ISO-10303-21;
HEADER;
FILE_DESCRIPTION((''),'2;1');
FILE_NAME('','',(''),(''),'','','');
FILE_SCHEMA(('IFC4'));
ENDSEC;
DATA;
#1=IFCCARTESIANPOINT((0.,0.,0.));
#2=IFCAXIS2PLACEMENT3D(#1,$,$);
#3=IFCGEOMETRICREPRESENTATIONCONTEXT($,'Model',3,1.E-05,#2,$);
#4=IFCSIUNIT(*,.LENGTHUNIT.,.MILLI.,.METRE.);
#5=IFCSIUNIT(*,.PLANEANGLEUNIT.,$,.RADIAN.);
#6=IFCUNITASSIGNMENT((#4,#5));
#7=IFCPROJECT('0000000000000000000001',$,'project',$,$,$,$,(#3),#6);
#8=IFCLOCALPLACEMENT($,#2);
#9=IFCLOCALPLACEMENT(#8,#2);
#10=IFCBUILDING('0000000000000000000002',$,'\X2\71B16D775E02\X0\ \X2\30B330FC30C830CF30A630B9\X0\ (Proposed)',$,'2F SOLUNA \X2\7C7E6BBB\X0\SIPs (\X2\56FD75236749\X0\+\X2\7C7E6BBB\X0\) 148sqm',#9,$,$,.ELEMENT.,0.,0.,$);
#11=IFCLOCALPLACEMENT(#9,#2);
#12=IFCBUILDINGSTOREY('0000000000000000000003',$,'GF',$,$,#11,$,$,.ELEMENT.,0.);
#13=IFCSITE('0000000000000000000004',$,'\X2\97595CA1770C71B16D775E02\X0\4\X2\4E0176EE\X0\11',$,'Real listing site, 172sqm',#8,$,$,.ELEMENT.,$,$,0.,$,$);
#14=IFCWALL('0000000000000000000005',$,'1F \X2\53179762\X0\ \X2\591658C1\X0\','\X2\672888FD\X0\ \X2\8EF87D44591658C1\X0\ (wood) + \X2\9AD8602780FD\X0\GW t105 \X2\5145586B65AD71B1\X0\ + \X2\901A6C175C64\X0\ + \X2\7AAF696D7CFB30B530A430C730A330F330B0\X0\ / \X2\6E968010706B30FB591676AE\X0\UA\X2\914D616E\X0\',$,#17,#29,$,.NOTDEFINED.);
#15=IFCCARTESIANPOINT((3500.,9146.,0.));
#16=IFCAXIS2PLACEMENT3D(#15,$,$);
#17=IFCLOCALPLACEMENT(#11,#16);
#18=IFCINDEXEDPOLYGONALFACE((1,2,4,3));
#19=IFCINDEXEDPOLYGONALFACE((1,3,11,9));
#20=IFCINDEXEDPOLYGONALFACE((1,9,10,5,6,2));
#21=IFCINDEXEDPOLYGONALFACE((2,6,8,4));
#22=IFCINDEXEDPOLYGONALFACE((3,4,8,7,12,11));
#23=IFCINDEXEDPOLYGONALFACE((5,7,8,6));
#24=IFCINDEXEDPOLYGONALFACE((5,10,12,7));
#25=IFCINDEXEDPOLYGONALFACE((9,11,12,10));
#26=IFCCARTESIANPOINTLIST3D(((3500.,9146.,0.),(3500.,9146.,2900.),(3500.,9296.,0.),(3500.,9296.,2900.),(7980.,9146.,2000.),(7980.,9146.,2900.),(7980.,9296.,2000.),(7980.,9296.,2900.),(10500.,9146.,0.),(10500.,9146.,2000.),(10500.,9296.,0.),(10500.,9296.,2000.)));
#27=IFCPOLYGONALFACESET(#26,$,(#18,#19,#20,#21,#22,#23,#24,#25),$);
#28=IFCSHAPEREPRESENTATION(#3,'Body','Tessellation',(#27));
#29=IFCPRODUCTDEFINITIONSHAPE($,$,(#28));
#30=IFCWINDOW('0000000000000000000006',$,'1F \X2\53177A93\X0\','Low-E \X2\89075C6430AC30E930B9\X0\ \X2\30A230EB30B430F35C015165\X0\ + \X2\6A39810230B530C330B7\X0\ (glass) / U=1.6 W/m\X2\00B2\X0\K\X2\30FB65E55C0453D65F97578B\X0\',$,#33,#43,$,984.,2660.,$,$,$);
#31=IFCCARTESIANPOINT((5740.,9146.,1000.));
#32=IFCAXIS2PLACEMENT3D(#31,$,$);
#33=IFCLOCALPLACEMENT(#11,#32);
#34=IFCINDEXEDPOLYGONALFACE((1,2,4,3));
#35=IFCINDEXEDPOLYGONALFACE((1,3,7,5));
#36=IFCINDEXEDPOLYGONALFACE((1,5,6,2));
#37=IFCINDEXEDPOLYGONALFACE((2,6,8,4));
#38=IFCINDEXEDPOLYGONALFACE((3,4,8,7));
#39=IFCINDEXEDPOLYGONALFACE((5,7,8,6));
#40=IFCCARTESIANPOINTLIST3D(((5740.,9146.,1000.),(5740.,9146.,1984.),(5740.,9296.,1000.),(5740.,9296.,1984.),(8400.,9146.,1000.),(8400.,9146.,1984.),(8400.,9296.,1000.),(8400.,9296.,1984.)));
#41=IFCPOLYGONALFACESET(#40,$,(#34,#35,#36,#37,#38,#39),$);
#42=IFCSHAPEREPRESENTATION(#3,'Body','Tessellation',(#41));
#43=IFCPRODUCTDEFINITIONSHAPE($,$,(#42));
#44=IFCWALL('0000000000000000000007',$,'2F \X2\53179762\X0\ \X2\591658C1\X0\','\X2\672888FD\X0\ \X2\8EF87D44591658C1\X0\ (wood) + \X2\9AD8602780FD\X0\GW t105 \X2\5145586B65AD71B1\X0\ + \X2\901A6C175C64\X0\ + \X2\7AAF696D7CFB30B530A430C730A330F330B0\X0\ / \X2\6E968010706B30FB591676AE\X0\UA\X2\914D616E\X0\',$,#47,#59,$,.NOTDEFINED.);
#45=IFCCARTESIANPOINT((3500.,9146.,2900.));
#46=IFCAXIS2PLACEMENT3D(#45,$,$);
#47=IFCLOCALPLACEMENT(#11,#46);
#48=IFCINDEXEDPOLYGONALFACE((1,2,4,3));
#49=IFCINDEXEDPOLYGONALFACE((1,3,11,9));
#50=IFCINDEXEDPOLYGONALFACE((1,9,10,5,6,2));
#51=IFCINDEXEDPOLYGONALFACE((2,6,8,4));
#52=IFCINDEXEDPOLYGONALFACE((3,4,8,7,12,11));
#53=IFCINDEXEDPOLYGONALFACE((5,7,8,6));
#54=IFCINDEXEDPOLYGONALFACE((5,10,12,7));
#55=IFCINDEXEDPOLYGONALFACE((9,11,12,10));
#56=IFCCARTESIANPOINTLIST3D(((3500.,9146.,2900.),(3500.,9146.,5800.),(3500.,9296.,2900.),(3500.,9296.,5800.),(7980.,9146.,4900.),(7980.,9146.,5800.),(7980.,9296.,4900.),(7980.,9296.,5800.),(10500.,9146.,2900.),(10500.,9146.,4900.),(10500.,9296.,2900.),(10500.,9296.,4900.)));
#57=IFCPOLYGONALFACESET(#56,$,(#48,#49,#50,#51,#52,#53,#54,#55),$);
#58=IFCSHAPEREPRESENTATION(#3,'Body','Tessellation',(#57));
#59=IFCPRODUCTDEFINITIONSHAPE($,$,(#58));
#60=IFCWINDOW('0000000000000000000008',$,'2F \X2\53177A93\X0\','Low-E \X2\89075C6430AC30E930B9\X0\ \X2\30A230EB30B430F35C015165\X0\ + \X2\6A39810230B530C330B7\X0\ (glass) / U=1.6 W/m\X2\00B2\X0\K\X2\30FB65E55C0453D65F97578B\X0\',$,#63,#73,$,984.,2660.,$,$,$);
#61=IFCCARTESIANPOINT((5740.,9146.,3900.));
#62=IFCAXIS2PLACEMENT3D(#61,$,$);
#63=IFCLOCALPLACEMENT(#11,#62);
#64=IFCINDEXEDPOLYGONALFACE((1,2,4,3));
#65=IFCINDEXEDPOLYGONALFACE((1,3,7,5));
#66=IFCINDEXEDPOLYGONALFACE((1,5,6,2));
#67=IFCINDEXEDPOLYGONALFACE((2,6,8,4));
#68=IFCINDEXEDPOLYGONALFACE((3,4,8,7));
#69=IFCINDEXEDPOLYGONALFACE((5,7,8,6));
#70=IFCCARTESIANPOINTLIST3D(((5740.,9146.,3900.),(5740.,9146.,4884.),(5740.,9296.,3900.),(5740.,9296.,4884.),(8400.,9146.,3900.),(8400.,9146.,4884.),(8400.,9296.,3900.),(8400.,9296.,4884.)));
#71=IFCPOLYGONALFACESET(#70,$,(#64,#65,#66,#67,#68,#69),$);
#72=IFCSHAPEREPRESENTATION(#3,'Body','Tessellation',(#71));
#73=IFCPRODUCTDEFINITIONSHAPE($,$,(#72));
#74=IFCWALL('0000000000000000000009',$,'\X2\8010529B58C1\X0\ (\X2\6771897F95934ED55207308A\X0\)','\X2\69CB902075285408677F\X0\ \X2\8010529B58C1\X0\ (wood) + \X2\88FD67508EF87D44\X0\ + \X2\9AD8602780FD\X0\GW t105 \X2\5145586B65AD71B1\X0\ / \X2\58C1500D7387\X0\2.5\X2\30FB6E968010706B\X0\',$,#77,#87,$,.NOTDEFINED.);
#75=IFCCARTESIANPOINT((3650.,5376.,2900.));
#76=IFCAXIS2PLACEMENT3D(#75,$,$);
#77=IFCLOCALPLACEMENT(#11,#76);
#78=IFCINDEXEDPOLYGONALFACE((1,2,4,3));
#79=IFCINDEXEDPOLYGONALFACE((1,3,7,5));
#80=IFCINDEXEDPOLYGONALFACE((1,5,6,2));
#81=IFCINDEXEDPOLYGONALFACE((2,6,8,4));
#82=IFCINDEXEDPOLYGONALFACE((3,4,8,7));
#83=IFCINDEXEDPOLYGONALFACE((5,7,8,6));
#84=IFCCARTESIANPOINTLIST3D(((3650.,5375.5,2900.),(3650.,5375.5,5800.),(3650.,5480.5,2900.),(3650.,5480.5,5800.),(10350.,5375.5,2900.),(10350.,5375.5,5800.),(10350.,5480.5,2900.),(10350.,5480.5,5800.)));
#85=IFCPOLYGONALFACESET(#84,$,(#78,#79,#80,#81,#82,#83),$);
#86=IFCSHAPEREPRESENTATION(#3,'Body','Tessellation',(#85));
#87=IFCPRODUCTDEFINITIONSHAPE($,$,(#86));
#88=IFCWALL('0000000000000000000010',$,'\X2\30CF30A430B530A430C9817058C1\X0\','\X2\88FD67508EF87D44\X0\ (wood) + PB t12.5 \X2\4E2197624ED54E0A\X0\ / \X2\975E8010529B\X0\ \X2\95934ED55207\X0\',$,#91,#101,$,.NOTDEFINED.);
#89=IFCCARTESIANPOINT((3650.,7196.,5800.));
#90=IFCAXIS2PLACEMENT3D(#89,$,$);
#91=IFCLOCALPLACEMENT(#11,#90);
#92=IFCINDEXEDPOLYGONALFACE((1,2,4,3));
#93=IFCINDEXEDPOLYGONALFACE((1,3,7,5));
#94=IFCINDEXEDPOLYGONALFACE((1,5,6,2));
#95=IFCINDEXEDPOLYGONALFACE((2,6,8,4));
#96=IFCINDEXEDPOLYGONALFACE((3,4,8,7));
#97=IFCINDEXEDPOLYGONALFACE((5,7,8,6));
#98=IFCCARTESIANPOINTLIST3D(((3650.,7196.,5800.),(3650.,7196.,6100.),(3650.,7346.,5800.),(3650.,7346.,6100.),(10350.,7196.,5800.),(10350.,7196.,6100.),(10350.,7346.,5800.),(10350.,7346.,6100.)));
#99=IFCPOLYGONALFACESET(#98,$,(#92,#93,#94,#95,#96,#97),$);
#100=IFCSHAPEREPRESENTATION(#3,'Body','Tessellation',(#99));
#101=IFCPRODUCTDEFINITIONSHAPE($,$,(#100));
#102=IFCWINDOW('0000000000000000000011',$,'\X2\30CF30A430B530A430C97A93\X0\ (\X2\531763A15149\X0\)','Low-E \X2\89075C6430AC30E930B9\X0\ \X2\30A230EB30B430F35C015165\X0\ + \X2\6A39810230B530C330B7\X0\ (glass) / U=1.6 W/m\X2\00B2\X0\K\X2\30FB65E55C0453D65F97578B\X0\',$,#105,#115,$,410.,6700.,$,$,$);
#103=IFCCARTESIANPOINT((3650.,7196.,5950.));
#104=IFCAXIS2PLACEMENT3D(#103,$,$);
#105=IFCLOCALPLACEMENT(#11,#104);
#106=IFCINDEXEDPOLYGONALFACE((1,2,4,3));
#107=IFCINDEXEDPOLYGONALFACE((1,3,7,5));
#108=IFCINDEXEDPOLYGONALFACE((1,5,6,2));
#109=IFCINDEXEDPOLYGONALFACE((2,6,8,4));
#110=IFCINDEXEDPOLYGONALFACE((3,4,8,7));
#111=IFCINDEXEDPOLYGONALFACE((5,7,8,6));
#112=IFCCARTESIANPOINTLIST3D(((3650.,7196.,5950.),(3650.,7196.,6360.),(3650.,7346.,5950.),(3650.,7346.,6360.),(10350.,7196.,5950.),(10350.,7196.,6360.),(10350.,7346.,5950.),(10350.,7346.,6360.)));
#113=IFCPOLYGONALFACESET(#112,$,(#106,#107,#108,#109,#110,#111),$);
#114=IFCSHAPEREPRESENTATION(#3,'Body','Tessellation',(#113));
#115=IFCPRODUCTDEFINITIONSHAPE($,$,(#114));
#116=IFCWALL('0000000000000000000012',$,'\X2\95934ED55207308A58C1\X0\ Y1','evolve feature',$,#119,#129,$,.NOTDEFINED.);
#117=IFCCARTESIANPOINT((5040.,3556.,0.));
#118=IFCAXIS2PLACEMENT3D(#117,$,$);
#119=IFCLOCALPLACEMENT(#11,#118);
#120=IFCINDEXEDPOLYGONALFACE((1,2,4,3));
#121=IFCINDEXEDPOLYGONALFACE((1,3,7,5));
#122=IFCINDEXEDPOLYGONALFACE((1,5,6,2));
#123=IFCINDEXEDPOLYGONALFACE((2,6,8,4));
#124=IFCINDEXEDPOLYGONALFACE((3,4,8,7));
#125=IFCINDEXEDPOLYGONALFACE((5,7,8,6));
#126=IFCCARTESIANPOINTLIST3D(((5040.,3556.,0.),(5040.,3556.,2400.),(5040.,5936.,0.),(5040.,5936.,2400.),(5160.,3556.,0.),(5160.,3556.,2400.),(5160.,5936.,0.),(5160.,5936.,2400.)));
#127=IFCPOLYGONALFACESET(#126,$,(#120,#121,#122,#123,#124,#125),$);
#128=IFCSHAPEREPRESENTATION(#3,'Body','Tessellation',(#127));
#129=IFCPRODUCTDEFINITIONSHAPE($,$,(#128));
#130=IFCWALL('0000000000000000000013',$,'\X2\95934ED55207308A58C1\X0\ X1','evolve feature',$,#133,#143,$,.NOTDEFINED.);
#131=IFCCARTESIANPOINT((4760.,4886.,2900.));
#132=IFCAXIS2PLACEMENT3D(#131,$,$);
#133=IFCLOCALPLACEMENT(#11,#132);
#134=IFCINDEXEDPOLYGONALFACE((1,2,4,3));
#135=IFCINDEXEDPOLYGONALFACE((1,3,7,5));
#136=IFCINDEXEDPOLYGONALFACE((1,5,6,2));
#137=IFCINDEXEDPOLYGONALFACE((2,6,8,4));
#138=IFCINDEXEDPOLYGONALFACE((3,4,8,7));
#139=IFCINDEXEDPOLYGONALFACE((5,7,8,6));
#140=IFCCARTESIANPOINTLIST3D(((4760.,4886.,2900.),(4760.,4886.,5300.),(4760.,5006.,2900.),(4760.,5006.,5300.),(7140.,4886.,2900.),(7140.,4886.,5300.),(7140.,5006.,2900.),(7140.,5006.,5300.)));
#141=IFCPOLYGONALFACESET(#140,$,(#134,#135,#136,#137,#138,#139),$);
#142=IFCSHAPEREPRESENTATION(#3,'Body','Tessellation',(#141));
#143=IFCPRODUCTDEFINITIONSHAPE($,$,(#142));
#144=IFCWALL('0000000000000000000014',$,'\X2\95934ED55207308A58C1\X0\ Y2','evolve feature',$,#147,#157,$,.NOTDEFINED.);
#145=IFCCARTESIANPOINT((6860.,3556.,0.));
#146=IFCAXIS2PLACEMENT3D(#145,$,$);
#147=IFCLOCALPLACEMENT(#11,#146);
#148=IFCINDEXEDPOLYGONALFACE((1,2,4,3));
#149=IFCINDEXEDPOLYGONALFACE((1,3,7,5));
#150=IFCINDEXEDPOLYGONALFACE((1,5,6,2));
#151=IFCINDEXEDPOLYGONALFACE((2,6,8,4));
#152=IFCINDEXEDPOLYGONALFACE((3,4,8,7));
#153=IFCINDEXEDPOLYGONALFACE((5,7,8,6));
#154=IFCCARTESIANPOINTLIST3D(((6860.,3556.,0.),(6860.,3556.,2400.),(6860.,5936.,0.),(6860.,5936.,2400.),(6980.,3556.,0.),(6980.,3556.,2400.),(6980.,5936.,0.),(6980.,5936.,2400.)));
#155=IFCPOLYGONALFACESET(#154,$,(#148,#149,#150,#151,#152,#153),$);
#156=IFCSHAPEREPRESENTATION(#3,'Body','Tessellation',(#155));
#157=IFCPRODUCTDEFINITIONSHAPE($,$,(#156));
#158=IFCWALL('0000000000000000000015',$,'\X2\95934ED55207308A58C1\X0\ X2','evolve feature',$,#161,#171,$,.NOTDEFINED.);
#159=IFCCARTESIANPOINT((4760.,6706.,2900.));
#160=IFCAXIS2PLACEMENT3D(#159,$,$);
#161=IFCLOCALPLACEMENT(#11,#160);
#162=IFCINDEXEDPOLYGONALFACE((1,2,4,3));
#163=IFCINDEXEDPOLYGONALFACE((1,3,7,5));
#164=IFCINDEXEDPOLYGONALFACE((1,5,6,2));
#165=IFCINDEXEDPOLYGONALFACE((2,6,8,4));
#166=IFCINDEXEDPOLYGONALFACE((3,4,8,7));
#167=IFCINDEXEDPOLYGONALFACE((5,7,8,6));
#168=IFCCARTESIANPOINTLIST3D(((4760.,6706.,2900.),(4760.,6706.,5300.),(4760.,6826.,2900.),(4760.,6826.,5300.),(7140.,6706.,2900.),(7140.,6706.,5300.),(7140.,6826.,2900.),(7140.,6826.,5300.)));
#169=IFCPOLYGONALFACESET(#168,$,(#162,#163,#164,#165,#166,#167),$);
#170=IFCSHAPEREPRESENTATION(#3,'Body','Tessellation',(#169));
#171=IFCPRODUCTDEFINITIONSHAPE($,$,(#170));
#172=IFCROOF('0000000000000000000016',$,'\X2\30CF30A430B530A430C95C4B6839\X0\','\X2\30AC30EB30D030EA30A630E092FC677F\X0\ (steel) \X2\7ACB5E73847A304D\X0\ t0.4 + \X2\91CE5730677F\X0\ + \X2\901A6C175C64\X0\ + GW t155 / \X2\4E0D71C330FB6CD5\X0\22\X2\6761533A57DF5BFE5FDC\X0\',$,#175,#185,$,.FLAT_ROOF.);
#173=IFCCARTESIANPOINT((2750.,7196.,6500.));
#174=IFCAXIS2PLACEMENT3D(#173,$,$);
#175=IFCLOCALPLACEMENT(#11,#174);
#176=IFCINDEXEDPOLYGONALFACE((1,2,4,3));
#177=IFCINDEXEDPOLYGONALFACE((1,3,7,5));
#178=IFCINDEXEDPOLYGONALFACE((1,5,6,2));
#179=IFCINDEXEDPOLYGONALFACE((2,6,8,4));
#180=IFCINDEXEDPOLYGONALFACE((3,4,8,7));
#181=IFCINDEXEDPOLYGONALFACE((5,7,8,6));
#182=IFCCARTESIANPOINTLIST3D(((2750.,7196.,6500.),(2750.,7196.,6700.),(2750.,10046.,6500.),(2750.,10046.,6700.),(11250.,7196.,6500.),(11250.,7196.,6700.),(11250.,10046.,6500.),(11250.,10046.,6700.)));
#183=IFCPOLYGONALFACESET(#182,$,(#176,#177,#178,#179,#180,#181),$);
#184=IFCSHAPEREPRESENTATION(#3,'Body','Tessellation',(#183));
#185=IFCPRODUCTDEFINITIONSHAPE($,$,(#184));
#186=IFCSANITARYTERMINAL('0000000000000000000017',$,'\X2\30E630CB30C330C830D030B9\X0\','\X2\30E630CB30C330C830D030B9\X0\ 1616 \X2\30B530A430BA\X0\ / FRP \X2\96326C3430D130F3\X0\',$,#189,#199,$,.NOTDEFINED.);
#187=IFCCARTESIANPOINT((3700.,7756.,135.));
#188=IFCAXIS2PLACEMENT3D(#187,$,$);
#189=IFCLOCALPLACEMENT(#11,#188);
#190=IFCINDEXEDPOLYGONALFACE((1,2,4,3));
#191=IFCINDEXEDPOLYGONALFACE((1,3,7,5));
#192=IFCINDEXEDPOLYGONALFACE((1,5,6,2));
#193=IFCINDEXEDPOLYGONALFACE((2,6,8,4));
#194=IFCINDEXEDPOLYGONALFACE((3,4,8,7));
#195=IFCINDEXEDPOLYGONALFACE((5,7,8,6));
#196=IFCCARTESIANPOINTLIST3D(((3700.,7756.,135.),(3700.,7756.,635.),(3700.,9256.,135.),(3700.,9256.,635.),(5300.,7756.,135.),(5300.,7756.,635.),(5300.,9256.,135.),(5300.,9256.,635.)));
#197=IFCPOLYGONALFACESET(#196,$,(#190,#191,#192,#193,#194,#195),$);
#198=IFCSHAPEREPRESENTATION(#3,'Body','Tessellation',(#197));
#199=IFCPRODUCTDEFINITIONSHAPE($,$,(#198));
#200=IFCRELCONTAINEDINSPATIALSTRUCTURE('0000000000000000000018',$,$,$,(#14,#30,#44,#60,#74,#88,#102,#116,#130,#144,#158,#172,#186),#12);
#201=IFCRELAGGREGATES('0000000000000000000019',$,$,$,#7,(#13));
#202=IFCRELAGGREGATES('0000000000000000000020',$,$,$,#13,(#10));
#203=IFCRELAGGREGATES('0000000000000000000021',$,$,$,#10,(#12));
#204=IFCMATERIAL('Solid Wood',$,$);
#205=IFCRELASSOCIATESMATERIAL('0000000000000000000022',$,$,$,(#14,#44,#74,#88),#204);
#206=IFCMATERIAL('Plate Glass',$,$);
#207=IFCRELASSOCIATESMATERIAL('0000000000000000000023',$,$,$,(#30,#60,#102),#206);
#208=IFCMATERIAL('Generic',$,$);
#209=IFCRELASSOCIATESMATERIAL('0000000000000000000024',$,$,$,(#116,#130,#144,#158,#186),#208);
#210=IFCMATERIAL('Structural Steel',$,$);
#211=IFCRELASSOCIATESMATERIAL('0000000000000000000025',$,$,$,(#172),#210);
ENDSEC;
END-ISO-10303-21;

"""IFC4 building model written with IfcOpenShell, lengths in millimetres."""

from ifc_helpers import new_model, si_unit, frame, frame_2d, origin, place, context, project, spatial, rectangle, extrude, material, element, fill, save


model = new_model("IFC4")

# Units and contexts
model_context = context("Model", 3, precision=1e-05, world=origin())
ifc_project = project(units=[si_unit("LENGTHUNIT", "METRE", prefix="MILLI"), si_unit("PLANEANGLEUNIT", "RADIAN")], contexts=[model_context])

# Site, building, storey
site_placement = place(None, origin())
site = spatial("IfcSite", under=ifc_project, at=site_placement, Name="静岡県熱海市4丁目11", ObjectType="Real listing site, 172sqm", CompositionType="ELEMENT", RefElevation=0.0)
building_placement = place(site_placement, origin())
building = spatial("IfcBuilding", under=site, at=building_placement, Name="熱海市 コートハウス (Proposed)", ObjectType="2F SOLUNA 籾殻SIPs (国産杉+籾殻) 148sqm", CompositionType="ELEMENT", ElevationOfRefHeight=0.0, ElevationOfTerrain=0.0)
storey_placement = place(building_placement, origin())
storey = spatial("IfcBuildingStorey", under=building, at=storey_placement, Name="GF", CompositionType="ELEMENT", Elevation=0.0)

# Wall, opening, window
ifc_material_1 = material(Name="Solid Wood")
wall_1_placement = place(storey_placement, frame((3500.0, 9146.0, 0.0)))
wall_1 = element("IfcWall", 1, at=wall_1_placement, inside=storey, material=ifc_material_1, Name="1F 北面 外壁", Description="木製 軸組外壁 (wood) + 高性能GW t105 充填断熱 + 通気層 + 窯業系サイディング / 準耐火・外皮UA配慮", PredefinedType="NOTDEFINED", context=model_context, shape_type="SweptSolid", body=[
    extrude(rectangle(XDim=7000.0, YDim=150.0, at=frame_2d((3500.0, 75.0))), frame((3500.0, 9146.0, 0.0)), (0.0, 0.0, 1.0), 2900.0),
])
opening_1_placement = place(storey_placement, frame((5740.0, 9146.0, 1000.0)))
opening_1 = element("IfcOpeningElement", 2, at=opening_1_placement, cuts=wall_1, PredefinedType="NOTDEFINED", context=model_context, shape_type="SweptSolid", body=[
    extrude(rectangle(XDim=2660.0, YDim=150.0, at=frame_2d((1330.0, 75.0))), frame((5740.0, 9146.0, 1000.0)), (0.0, 0.0, 1.0), 984.0),
])
ifc_material_2 = material(Name="Plate Glass")
window_1_placement = place(storey_placement, frame((5740.0, 9146.0, 1000.0)))
window_1 = element("IfcWindow", 3, at=window_1_placement, inside=storey, material=ifc_material_2, Name="1F 北窓", Description="Low-E 複層ガラス アルゴン封入 + 樹脂サッシ (glass) / U=1.6 W/m²K・日射取得型", OverallHeight=984.0, OverallWidth=2660.0, context=model_context, shape_type="SweptSolid", body=[
    extrude(rectangle(XDim=2660.0, YDim=150.0, at=frame_2d((1330.0, 75.0))), frame((5740.0, 9146.0, 1000.0)), (0.0, 0.0, 1.0), 984.0),
])
fill(opening_1, window_1)

# Wall, opening, window
wall_2_placement = place(storey_placement, frame((3500.0, 9146.0, 2900.0)))
wall_2 = element("IfcWall", 4, at=wall_2_placement, inside=storey, material=ifc_material_1, Name="2F 北面 外壁", Description="木製 軸組外壁 (wood) + 高性能GW t105 充填断熱 + 通気層 + 窯業系サイディング / 準耐火・外皮UA配慮", PredefinedType="NOTDEFINED", context=model_context, shape_type="SweptSolid", body=[
    extrude(rectangle(XDim=7000.0, YDim=150.0, at=frame_2d((3500.0, 75.0))), frame((3500.0, 9146.0, 2900.0)), (0.0, 0.0, 1.0), 2900.0),
])
opening_2_placement = place(storey_placement, frame((5740.0, 9146.0, 3900.0)))
opening_2 = element("IfcOpeningElement", 5, at=opening_2_placement, cuts=wall_2, PredefinedType="NOTDEFINED", context=model_context, shape_type="SweptSolid", body=[
    extrude(rectangle(XDim=2660.0, YDim=150.0, at=frame_2d((1330.0, 75.0))), frame((5740.0, 9146.0, 3900.0)), (0.0, 0.0, 1.0), 984.0),
])
window_2_placement = place(storey_placement, frame((5740.0, 9146.0, 3900.0)))
window_2 = element("IfcWindow", 6, at=window_2_placement, inside=storey, material=ifc_material_2, Name="2F 北窓", Description="Low-E 複層ガラス アルゴン封入 + 樹脂サッシ (glass) / U=1.6 W/m²K・日射取得型", OverallHeight=984.0, OverallWidth=2660.0, context=model_context, shape_type="SweptSolid", body=[
    extrude(rectangle(XDim=2660.0, YDim=150.0, at=frame_2d((1330.0, 75.0))), frame((5740.0, 9146.0, 3900.0)), (0.0, 0.0, 1.0), 984.0),
])
fill(opening_2, window_2)

# Wall
wall_3_placement = place(storey_placement, frame((3650.0, 5376.0, 2900.0)))
element("IfcWall", 7, at=wall_3_placement, inside=storey, material=ifc_material_1, Name="耐力壁 (東西間仕切り)", Description="構造用合板 耐力壁 (wood) + 製材軸組 + 高性能GW t105 充填断熱 / 壁倍率2.5・準耐火", PredefinedType="NOTDEFINED", context=model_context, shape_type="SweptSolid", body=[
    extrude(rectangle(XDim=6700.0, YDim=105.0, at=frame_2d((3350.0, 52.0))), frame((3650.0, 5376.0, 2900.0)), (0.0, 0.0, 1.0), 2900.0),
])

# Wall, opening, window
wall_4_placement = place(storey_placement, frame((3650.0, 7196.0, 5800.0)))
wall_4 = element("IfcWall", 8, at=wall_4_placement, inside=storey, material=ifc_material_1, Name="ハイサイド腰壁", Description="製材軸組 (wood) + PB t12.5 両面仕上 / 非耐力 間仕切", PredefinedType="NOTDEFINED", context=model_context, shape_type="SweptSolid", body=[
    extrude(rectangle(XDim=6700.0, YDim=150.0, at=frame_2d((3350.0, 75.0))), frame((3650.0, 7196.0, 5800.0)), (0.0, 0.0, 1.0), 700.0),
])
opening_3_placement = place(storey_placement, frame((3650.0, 7196.0, 5950.0)))
opening_3 = element("IfcOpeningElement", 9, at=opening_3_placement, cuts=wall_4, PredefinedType="NOTDEFINED", context=model_context, shape_type="SweptSolid", body=[
    extrude(rectangle(XDim=6700.0, YDim=150.0, at=frame_2d((3350.0, 75.0))), frame((3650.0, 7196.0, 5950.0)), (0.0, 0.0, 1.0), 410.0),
])
window_3_placement = place(storey_placement, frame((3650.0, 7196.0, 5950.0)))
window_3 = element("IfcWindow", 10, at=window_3_placement, inside=storey, material=ifc_material_2, Name="ハイサイド窓 (北採光)", Description="Low-E 複層ガラス アルゴン封入 + 樹脂サッシ (glass) / U=1.6 W/m²K・日射取得型", OverallHeight=410.0, OverallWidth=6700.0, context=model_context, shape_type="SweptSolid", body=[
    extrude(rectangle(XDim=6700.0, YDim=150.0, at=frame_2d((3350.0, 75.0))), frame((3650.0, 7196.0, 5950.0)), (0.0, 0.0, 1.0), 410.0),
])
fill(opening_3, window_3)

# Walls
ifc_material_3 = material(Name="Generic")
wall_5_placement = place(storey_placement, frame((5040.0, 3556.0, 0.0)))
element("IfcWall", 11, at=wall_5_placement, inside=storey, material=ifc_material_3, Name="間仕切り壁 Y1", Description="evolve feature", PredefinedType="NOTDEFINED", context=model_context, shape_type="SweptSolid", body=[
    extrude(rectangle(XDim=120.0, YDim=2380.0, at=frame_2d((60.0, 1190.0))), frame((5040.0, 3556.0, 0.0)), (0.0, 0.0, 1.0), 2400.0),
])
wall_6_placement = place(storey_placement, frame((4760.0, 4886.0, 2900.0)))
element("IfcWall", 12, at=wall_6_placement, inside=storey, material=ifc_material_3, Name="間仕切り壁 X1", Description="evolve feature", PredefinedType="NOTDEFINED", context=model_context, shape_type="SweptSolid", body=[
    extrude(rectangle(XDim=2380.0, YDim=120.0, at=frame_2d((1190.0, 60.0))), frame((4760.0, 4886.0, 2900.0)), (0.0, 0.0, 1.0), 2400.0),
])
wall_7_placement = place(storey_placement, frame((6860.0, 3556.0, 0.0)))
element("IfcWall", 13, at=wall_7_placement, inside=storey, material=ifc_material_3, Name="間仕切り壁 Y2", Description="evolve feature", PredefinedType="NOTDEFINED", context=model_context, shape_type="SweptSolid", body=[
    extrude(rectangle(XDim=120.0, YDim=2380.0, at=frame_2d((60.0, 1190.0))), frame((6860.0, 3556.0, 0.0)), (0.0, 0.0, 1.0), 2400.0),
])
wall_8_placement = place(storey_placement, frame((4760.0, 6706.0, 2900.0)))
element("IfcWall", 14, at=wall_8_placement, inside=storey, material=ifc_material_3, Name="間仕切り壁 X2", Description="evolve feature", PredefinedType="NOTDEFINED", context=model_context, shape_type="SweptSolid", body=[
    extrude(rectangle(XDim=2380.0, YDim=120.0, at=frame_2d((1190.0, 60.0))), frame((4760.0, 6706.0, 2900.0)), (0.0, 0.0, 1.0), 2400.0),
])

# Roof
ifc_material_4 = material(Name="Structural Steel")
roof_placement = place(storey_placement, frame((2750.0, 7196.0, 6500.0)))
element("IfcRoof", 15, at=roof_placement, inside=storey, material=ifc_material_4, Name="ハイサイド屋根", Description="ガルバリウム鋼板 (steel) 立平葺き t0.4 + 野地板 + 通気層 + GW t155 / 不燃・法22条区域対応", PredefinedType="FLAT_ROOF", context=model_context, shape_type="SweptSolid", body=[
    extrude(rectangle(XDim=8500.0, YDim=2850.0, at=frame_2d((4250.0, 1425.0))), frame((2750.0, 7196.0, 6500.0)), (0.0, 0.0, 1.0), 200.0),
])

# Sanitary terminal
sanitary_terminal_1_placement = place(storey_placement, frame((3700.0, 7756.0, 135.0)))
element("IfcSanitaryTerminal", 16, at=sanitary_terminal_1_placement, inside=storey, material=ifc_material_3, Name="ユニットバス", Description="ユニットバス 1616 サイズ / FRP 防水パン", PredefinedType="NOTDEFINED", context=model_context, shape_type="SweptSolid", body=[
    extrude(rectangle(XDim=1600.0, YDim=1500.0, at=frame_2d((800.0, 750.0))), frame((3700.0, 7756.0, 135.0)), (0.0, 0.0, 1.0), 500.0),
])

save(model, "model.ifc")
